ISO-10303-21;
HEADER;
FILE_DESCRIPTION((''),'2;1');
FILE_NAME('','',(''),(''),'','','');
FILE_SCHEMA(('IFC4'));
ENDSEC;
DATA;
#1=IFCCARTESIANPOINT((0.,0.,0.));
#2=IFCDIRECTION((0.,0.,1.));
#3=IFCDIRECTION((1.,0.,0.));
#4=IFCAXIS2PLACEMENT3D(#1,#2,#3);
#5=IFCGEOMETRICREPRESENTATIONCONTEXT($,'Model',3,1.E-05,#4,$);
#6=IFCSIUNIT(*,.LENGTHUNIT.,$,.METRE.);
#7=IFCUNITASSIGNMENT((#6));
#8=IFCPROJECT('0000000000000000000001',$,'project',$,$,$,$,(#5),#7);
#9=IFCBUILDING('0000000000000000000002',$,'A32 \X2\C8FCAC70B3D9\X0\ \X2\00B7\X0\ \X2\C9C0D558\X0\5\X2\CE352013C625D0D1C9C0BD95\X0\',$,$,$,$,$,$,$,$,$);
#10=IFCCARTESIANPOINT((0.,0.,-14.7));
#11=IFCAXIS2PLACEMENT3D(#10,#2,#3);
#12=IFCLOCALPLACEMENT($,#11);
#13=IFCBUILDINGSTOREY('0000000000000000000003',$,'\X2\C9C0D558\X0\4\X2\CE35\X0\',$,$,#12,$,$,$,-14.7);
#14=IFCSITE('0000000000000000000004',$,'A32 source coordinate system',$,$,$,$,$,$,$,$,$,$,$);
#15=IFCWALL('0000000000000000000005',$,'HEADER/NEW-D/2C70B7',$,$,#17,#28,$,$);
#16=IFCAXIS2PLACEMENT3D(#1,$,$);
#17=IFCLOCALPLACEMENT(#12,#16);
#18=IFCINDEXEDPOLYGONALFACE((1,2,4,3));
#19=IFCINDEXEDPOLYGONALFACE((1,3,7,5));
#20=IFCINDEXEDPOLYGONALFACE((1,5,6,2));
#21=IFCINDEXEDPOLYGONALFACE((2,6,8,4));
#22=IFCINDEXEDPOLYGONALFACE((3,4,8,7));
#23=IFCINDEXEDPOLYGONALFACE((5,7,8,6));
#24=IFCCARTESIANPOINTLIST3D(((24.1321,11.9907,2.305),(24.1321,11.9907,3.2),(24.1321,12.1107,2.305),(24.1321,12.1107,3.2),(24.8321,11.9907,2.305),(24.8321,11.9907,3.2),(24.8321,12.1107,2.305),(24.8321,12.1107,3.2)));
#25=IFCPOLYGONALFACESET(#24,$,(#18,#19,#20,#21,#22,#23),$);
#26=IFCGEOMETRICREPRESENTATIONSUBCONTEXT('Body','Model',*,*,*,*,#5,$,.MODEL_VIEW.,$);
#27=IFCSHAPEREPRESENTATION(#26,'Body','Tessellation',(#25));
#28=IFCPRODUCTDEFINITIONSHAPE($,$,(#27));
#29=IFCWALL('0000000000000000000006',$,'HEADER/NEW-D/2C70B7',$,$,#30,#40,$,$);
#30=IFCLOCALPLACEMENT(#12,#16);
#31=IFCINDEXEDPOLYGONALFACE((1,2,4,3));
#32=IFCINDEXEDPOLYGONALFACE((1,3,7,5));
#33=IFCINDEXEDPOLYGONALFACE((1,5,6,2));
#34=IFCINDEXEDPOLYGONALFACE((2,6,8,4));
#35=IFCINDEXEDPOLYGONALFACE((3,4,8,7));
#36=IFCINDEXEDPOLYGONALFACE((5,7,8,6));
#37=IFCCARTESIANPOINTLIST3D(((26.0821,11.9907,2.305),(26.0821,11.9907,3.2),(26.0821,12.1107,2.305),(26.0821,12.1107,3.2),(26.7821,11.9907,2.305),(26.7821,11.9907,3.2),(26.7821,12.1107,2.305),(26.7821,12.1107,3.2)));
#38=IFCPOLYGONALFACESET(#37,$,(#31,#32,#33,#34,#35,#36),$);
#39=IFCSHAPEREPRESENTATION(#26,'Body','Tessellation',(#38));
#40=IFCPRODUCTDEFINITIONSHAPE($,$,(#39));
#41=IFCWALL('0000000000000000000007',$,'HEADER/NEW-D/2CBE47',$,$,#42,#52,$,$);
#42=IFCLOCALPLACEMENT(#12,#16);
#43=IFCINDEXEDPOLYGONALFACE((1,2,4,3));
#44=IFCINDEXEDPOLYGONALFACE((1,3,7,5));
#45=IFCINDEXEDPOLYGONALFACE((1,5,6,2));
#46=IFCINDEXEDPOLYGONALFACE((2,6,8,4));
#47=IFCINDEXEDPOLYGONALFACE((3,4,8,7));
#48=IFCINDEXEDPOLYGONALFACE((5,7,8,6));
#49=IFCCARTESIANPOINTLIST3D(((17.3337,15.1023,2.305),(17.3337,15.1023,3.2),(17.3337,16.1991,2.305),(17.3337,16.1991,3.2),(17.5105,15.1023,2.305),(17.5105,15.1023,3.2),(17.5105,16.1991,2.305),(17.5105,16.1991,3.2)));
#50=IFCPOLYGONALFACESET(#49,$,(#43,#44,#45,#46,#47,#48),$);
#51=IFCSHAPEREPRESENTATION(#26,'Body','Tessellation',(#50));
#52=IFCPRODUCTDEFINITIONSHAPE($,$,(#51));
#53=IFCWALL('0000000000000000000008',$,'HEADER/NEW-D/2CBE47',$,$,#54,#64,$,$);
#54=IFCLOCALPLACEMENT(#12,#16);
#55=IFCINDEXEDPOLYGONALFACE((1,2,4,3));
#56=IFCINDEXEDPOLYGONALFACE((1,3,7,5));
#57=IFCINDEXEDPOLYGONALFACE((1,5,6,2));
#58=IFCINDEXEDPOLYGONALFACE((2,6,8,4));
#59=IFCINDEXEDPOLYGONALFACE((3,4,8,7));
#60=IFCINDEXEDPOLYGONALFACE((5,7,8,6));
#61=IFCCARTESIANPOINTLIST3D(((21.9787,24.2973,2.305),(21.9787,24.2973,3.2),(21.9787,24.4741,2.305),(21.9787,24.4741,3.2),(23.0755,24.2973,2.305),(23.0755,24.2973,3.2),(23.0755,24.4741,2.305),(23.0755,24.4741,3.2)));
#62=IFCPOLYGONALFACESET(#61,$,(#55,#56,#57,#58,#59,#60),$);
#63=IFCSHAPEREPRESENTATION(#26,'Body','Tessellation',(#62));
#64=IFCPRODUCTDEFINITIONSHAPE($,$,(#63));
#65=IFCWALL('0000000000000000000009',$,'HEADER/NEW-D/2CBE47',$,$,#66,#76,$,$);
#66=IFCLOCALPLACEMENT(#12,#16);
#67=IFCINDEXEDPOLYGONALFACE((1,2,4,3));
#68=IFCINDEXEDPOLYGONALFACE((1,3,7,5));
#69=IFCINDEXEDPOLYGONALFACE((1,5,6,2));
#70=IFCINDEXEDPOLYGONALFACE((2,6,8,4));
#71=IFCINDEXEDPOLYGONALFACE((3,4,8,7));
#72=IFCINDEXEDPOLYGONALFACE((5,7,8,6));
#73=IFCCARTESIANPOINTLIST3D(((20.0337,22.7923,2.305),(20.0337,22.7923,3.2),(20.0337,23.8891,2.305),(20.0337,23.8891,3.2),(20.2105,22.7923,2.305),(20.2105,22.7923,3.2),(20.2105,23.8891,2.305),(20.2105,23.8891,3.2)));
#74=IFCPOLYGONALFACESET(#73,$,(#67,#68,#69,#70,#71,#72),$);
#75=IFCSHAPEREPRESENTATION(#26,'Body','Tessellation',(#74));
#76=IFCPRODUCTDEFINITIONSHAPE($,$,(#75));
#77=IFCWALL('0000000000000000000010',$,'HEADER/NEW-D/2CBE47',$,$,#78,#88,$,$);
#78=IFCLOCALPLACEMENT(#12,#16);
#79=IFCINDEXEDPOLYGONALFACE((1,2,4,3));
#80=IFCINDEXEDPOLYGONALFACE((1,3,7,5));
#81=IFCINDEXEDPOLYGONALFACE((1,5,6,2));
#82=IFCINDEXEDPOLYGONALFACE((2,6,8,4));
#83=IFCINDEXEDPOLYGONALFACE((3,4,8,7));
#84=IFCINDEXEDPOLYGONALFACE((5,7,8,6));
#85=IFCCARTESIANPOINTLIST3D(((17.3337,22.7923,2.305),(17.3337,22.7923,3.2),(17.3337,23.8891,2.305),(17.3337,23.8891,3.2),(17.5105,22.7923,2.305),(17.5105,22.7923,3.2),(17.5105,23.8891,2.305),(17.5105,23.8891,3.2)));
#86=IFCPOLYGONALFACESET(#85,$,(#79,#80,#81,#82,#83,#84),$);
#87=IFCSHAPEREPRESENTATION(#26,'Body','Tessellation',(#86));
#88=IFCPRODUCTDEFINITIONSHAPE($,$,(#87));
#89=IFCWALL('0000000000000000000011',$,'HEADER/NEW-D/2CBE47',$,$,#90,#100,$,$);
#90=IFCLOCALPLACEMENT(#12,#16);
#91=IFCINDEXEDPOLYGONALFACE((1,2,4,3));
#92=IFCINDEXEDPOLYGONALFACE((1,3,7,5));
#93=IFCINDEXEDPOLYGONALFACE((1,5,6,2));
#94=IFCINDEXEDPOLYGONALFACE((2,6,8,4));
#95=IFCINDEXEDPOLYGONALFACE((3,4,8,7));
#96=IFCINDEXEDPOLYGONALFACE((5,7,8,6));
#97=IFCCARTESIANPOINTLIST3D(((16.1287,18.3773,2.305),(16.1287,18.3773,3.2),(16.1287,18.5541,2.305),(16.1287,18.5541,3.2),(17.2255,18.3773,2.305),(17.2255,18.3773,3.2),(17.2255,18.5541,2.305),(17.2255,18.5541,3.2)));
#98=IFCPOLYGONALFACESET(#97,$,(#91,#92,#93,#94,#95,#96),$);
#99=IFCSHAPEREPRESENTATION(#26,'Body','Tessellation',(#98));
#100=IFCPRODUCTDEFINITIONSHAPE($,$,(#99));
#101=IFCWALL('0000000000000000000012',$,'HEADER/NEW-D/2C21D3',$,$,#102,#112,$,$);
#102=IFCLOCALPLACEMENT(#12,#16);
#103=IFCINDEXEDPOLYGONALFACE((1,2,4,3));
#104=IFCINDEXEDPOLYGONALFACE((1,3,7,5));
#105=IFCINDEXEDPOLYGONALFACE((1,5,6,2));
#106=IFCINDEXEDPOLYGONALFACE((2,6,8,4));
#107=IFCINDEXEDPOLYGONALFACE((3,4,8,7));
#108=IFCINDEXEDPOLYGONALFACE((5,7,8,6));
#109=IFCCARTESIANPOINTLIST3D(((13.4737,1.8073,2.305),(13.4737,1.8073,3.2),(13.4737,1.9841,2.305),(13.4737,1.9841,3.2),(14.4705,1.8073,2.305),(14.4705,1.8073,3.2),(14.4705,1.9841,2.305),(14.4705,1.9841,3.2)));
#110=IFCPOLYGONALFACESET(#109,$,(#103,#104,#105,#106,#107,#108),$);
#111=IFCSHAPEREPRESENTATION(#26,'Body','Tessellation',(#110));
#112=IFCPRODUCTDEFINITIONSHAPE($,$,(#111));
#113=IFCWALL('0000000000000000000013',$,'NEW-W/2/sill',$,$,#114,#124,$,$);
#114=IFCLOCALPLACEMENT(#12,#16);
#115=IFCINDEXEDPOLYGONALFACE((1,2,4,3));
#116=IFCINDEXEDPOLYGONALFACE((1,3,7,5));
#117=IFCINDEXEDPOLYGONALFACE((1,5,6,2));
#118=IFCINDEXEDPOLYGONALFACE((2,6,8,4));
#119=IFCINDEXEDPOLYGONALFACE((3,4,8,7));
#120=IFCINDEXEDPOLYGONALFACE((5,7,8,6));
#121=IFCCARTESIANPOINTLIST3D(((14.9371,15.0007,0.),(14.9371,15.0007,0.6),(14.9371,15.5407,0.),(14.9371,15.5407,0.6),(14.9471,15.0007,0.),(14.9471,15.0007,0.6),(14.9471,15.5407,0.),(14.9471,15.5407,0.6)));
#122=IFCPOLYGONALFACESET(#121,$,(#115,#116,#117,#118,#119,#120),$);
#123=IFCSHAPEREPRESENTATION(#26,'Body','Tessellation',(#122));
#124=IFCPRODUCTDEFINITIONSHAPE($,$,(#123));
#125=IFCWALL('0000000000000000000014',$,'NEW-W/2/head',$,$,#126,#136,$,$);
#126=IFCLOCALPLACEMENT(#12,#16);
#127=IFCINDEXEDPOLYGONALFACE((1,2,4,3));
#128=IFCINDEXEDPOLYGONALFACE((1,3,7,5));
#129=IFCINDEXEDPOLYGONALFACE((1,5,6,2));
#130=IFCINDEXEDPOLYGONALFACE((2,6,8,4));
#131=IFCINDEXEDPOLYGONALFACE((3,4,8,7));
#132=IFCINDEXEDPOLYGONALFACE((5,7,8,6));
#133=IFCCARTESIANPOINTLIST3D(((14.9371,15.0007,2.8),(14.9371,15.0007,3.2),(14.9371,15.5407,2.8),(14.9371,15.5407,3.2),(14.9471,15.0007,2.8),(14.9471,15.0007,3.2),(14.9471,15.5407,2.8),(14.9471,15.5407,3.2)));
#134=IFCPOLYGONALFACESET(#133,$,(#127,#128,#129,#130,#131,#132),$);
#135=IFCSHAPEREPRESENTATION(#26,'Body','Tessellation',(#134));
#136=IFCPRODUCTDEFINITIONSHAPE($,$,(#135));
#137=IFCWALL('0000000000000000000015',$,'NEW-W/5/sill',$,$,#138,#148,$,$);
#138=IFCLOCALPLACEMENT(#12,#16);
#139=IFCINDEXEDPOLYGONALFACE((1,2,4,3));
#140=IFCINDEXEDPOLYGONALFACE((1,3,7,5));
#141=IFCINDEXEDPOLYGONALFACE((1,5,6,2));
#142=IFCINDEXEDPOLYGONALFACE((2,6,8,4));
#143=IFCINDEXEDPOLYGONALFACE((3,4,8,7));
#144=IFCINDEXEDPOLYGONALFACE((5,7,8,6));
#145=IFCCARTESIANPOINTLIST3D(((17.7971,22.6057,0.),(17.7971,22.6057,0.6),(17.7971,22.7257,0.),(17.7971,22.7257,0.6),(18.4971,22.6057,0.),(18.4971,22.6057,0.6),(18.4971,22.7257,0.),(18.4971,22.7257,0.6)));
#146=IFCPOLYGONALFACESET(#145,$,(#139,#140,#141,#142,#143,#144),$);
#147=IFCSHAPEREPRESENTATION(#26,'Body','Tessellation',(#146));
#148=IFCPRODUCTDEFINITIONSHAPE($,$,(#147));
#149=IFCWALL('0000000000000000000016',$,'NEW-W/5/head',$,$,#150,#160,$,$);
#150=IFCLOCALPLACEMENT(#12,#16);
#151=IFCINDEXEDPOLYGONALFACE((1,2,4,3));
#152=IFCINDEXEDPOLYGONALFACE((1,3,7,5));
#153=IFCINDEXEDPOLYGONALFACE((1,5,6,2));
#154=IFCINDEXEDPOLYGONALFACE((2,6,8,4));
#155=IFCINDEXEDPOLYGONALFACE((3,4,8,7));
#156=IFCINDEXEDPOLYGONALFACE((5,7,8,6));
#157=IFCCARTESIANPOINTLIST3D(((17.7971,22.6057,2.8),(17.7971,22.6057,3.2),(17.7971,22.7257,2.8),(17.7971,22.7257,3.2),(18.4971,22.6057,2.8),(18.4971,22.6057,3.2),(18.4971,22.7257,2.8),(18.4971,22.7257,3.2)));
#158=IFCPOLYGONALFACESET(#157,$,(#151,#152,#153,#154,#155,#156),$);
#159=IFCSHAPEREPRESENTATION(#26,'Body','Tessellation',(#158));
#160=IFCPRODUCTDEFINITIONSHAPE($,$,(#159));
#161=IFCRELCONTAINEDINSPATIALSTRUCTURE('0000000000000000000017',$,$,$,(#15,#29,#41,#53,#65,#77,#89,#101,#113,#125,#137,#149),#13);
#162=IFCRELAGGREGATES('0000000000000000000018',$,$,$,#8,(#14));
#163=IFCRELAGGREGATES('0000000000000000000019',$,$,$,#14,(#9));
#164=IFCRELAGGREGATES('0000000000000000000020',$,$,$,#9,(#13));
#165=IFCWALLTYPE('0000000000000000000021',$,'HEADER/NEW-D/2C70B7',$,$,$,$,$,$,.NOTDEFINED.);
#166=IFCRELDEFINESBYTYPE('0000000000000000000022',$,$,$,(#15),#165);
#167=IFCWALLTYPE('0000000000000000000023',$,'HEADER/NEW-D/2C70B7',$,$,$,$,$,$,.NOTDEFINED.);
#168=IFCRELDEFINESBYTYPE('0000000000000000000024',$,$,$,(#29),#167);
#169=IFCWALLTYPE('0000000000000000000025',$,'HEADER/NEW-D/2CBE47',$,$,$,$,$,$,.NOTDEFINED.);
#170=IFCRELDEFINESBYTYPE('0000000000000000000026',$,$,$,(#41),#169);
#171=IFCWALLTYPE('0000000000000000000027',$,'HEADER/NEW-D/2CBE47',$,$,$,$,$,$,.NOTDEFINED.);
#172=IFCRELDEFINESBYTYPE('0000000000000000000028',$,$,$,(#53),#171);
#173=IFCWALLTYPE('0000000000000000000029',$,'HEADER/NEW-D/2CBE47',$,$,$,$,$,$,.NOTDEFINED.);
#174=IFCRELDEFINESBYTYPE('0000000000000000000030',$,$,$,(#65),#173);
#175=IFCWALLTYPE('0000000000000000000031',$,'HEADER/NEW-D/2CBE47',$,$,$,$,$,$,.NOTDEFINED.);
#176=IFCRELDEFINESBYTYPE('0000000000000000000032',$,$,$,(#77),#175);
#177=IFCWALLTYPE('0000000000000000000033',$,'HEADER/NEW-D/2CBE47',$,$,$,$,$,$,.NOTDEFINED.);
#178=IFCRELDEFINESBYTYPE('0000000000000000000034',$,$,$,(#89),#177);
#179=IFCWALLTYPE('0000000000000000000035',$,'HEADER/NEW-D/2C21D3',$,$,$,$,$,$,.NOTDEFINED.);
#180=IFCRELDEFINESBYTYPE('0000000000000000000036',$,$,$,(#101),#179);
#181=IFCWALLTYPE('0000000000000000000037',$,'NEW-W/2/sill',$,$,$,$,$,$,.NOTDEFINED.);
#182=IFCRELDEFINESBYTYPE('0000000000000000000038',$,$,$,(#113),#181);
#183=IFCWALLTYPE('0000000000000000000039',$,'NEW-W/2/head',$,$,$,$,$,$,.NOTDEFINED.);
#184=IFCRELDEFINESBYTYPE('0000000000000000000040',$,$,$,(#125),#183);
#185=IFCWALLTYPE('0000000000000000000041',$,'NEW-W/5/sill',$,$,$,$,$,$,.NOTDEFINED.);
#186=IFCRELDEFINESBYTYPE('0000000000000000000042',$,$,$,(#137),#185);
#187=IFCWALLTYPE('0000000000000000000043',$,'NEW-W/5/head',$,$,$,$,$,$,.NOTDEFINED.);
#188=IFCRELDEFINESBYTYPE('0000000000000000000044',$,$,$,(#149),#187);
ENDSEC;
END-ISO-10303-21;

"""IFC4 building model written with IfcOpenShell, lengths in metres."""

from ifc_helpers import new_model, si_unit, frame, origin, origin_with_axes, place, context, subcontext, project, spatial, polyline, outline, extrude, source, transform, mapped, type_object, type_shapes, element, save


model = new_model("IFC4")

# Units and contexts
model_context = context("Model", 3, precision=1e-05, world=origin_with_axes())
body_context = subcontext(model_context, "Body", "Model", "MODEL_VIEW")
ifc_project = project(units=[si_unit("LENGTHUNIT", "METRE")], contexts=[model_context])

# Site, building, storey
site = spatial("IfcSite", under=ifc_project, Name="A32 source coordinate system")
building = spatial("IfcBuilding", under=site, Name="A32 주거동 · 지하5층–옥탑지붕")
storey_placement = place(None, frame((0.0, 0.0, -14.7), z_axis=(0.0, 0.0, 1.0), x_axis=(1.0, 0.0, 0.0)))
storey = spatial("IfcBuildingStorey", under=building, at=storey_placement, Name="지하4층", Elevation=-14.7)

# Walls
wall_type_1 = type_object("IfcWallType", Name="HEADER/NEW-D/2C70B7", PredefinedType="NOTDEFINED")
shared_shape_1 = source(origin(), body_context, "Body", "SweptSolid", [
    extrude(outline(polyline([(24.1321, 11.9907), (24.1321, 12.1107), (24.8321, 12.1107), (24.8321, 11.9907), (24.1321, 11.9907)])), frame((0.0, 0.0, 2.305)), (0.0, 0.0, 1.0), 0.895),
])
type_shapes(wall_type_1, [shared_shape_1])
wall_1_placement = place(storey_placement, origin_with_axes())
element("IfcWall", 1, at=wall_1_placement, inside=storey, type_object=wall_type_1, Name="HEADER/NEW-D/2C70B7", context=body_context, shape_type="MappedRepresentation", body=[
    mapped(shared_shape_1, transform((0.0, 0.0, 0.0), scale=1.0)),
])
wall_type_2 = type_object("IfcWallType", Name="HEADER/NEW-D/2C70B7", PredefinedType="NOTDEFINED")
shared_shape_2 = source(origin(), body_context, "Body", "SweptSolid", [
    extrude(outline(polyline([(26.0821, 11.9907), (26.0821, 12.1107), (26.7821, 12.1107), (26.7821, 11.9907), (26.0821, 11.9907)])), frame((0.0, 0.0, 2.305)), (0.0, 0.0, 1.0), 0.895),
])
type_shapes(wall_type_2, [shared_shape_2])
wall_2_placement = place(storey_placement, origin_with_axes())
element("IfcWall", 2, at=wall_2_placement, inside=storey, type_object=wall_type_2, Name="HEADER/NEW-D/2C70B7", context=body_context, shape_type="MappedRepresentation", body=[
    mapped(shared_shape_2, transform((0.0, 0.0, 0.0), scale=1.0)),
])
wall_type_3 = type_object("IfcWallType", Name="HEADER/NEW-D/2CBE47", PredefinedType="NOTDEFINED")
shared_shape_3 = source(origin(), body_context, "Body", "SweptSolid", [
    extrude(outline(polyline([(17.3337, 15.1023), (17.3337, 16.1991), (17.5105, 16.1991), (17.5105, 15.1023), (17.3337, 15.1023)])), frame((0.0, 0.0, 2.305)), (0.0, 0.0, 1.0), 0.895),
])
type_shapes(wall_type_3, [shared_shape_3])
wall_3_placement = place(storey_placement, origin_with_axes())
element("IfcWall", 3, at=wall_3_placement, inside=storey, type_object=wall_type_3, Name="HEADER/NEW-D/2CBE47", context=body_context, shape_type="MappedRepresentation", body=[
    mapped(shared_shape_3, transform((0.0, 0.0, 0.0), scale=1.0)),
])
wall_type_4 = type_object("IfcWallType", Name="HEADER/NEW-D/2CBE47", PredefinedType="NOTDEFINED")
shared_shape_4 = source(origin(), body_context, "Body", "SweptSolid", [
    extrude(outline(polyline([(21.9787, 24.2973), (21.9787, 24.4741), (23.0755, 24.4741), (23.0755, 24.2973), (21.9787, 24.2973)])), frame((0.0, 0.0, 2.305)), (0.0, 0.0, 1.0), 0.895),
])
type_shapes(wall_type_4, [shared_shape_4])
wall_4_placement = place(storey_placement, origin_with_axes())
element("IfcWall", 4, at=wall_4_placement, inside=storey, type_object=wall_type_4, Name="HEADER/NEW-D/2CBE47", context=body_context, shape_type="MappedRepresentation", body=[
    mapped(shared_shape_4, transform((0.0, 0.0, 0.0), scale=1.0)),
])
wall_type_5 = type_object("IfcWallType", Name="HEADER/NEW-D/2CBE47", PredefinedType="NOTDEFINED")
shared_shape_5 = source(origin(), body_context, "Body", "SweptSolid", [
    extrude(outline(polyline([(20.0337, 22.7923), (20.0337, 23.8891), (20.2105, 23.8891), (20.2105, 22.7923), (20.0337, 22.7923)])), frame((0.0, 0.0, 2.305)), (0.0, 0.0, 1.0), 0.895),
])
type_shapes(wall_type_5, [shared_shape_5])
wall_5_placement = place(storey_placement, origin_with_axes())
element("IfcWall", 5, at=wall_5_placement, inside=storey, type_object=wall_type_5, Name="HEADER/NEW-D/2CBE47", context=body_context, shape_type="MappedRepresentation", body=[
    mapped(shared_shape_5, transform((0.0, 0.0, 0.0), scale=1.0)),
])
wall_type_6 = type_object("IfcWallType", Name="HEADER/NEW-D/2CBE47", PredefinedType="NOTDEFINED")
shared_shape_6 = source(origin(), body_context, "Body", "SweptSolid", [
    extrude(outline(polyline([(17.3337, 22.7923), (17.3337, 23.8891), (17.5105, 23.8891), (17.5105, 22.7923), (17.3337, 22.7923)])), frame((0.0, 0.0, 2.305)), (0.0, 0.0, 1.0), 0.895),
])
type_shapes(wall_type_6, [shared_shape_6])
wall_6_placement = place(storey_placement, origin_with_axes())
element("IfcWall", 6, at=wall_6_placement, inside=storey, type_object=wall_type_6, Name="HEADER/NEW-D/2CBE47", context=body_context, shape_type="MappedRepresentation", body=[
    mapped(shared_shape_6, transform((0.0, 0.0, 0.0), scale=1.0)),
])
wall_type_7 = type_object("IfcWallType", Name="HEADER/NEW-D/2CBE47", PredefinedType="NOTDEFINED")
shared_shape_7 = source(origin(), body_context, "Body", "SweptSolid", [
    extrude(outline(polyline([(16.1287, 18.3773), (16.1287, 18.5541), (17.2255, 18.5541), (17.2255, 18.3773), (16.1287, 18.3773)])), frame((0.0, 0.0, 2.305)), (0.0, 0.0, 1.0), 0.895),
])
type_shapes(wall_type_7, [shared_shape_7])
wall_7_placement = place(storey_placement, origin_with_axes())
element("IfcWall", 7, at=wall_7_placement, inside=storey, type_object=wall_type_7, Name="HEADER/NEW-D/2CBE47", context=body_context, shape_type="MappedRepresentation", body=[
    mapped(shared_shape_7, transform((0.0, 0.0, 0.0), scale=1.0)),
])
wall_type_8 = type_object("IfcWallType", Name="HEADER/NEW-D/2C21D3", PredefinedType="NOTDEFINED")
shared_shape_8 = source(origin(), body_context, "Body", "SweptSolid", [
    extrude(outline(polyline([(13.4737, 1.8073), (13.4737, 1.9841), (14.4705, 1.9841), (14.4705, 1.8073), (13.4737, 1.8073)])), frame((0.0, 0.0, 2.305)), (0.0, 0.0, 1.0), 0.895),
])
type_shapes(wall_type_8, [shared_shape_8])
wall_8_placement = place(storey_placement, origin_with_axes())
element("IfcWall", 8, at=wall_8_placement, inside=storey, type_object=wall_type_8, Name="HEADER/NEW-D/2C21D3", context=body_context, shape_type="MappedRepresentation", body=[
    mapped(shared_shape_8, transform((0.0, 0.0, 0.0), scale=1.0)),
])
wall_type_9 = type_object("IfcWallType", Name="NEW-W/2/sill", PredefinedType="NOTDEFINED")
shared_shape_9 = source(origin(), body_context, "Body", "SweptSolid", [
    extrude(outline(polyline([(14.9471, 15.5407), (14.9471, 15.0007), (14.9371, 15.0007), (14.9371, 15.5407), (14.9471, 15.5407)])), origin(), (0.0, 0.0, 1.0), 0.6),
])
type_shapes(wall_type_9, [shared_shape_9])
wall_9_placement = place(storey_placement, origin_with_axes())
element("IfcWall", 9, at=wall_9_placement, inside=storey, type_object=wall_type_9, Name="NEW-W/2/sill", context=body_context, shape_type="MappedRepresentation", body=[
    mapped(shared_shape_9, transform((0.0, 0.0, 0.0), scale=1.0)),
])
wall_type_10 = type_object("IfcWallType", Name="NEW-W/2/head", PredefinedType="NOTDEFINED")
shared_shape_10 = source(origin(), body_context, "Body", "SweptSolid", [
    extrude(outline(polyline([(14.9471, 15.5407), (14.9471, 15.0007), (14.9371, 15.0007), (14.9371, 15.5407), (14.9471, 15.5407)])), frame((0.0, 0.0, 2.8)), (0.0, 0.0, 1.0), 0.4),
])
type_shapes(wall_type_10, [shared_shape_10])
wall_10_placement = place(storey_placement, origin_with_axes())
element("IfcWall", 10, at=wall_10_placement, inside=storey, type_object=wall_type_10, Name="NEW-W/2/head", context=body_context, shape_type="MappedRepresentation", body=[
    mapped(shared_shape_10, transform((0.0, 0.0, 0.0), scale=1.0)),
])
wall_type_11 = type_object("IfcWallType", Name="NEW-W/5/sill", PredefinedType="NOTDEFINED")
shared_shape_11 = source(origin(), body_context, "Body", "SweptSolid", [
    extrude(outline(polyline([(17.7971, 22.6057), (17.7971, 22.7257), (18.4971, 22.7257), (18.4971, 22.6057), (17.7971, 22.6057)])), origin(), (0.0, 0.0, 1.0), 0.6),
])
type_shapes(wall_type_11, [shared_shape_11])
wall_11_placement = place(storey_placement, origin_with_axes())
element("IfcWall", 11, at=wall_11_placement, inside=storey, type_object=wall_type_11, Name="NEW-W/5/sill", context=body_context, shape_type="MappedRepresentation", body=[
    mapped(shared_shape_11, transform((0.0, 0.0, 0.0), scale=1.0)),
])
wall_type_12 = type_object("IfcWallType", Name="NEW-W/5/head", PredefinedType="NOTDEFINED")
shared_shape_12 = source(origin(), body_context, "Body", "SweptSolid", [
    extrude(outline(polyline([(17.7971, 22.6057), (17.7971, 22.7257), (18.4971, 22.7257), (18.4971, 22.6057), (17.7971, 22.6057)])), frame((0.0, 0.0, 2.8)), (0.0, 0.0, 1.0), 0.4),
])
type_shapes(wall_type_12, [shared_shape_12])
wall_12_placement = place(storey_placement, origin_with_axes())
element("IfcWall", 12, at=wall_12_placement, inside=storey, type_object=wall_type_12, Name="NEW-W/5/head", context=body_context, shape_type="MappedRepresentation", body=[
    mapped(shared_shape_12, transform((0.0, 0.0, 0.0), scale=1.0)),
])

save(model, "model.ifc")
